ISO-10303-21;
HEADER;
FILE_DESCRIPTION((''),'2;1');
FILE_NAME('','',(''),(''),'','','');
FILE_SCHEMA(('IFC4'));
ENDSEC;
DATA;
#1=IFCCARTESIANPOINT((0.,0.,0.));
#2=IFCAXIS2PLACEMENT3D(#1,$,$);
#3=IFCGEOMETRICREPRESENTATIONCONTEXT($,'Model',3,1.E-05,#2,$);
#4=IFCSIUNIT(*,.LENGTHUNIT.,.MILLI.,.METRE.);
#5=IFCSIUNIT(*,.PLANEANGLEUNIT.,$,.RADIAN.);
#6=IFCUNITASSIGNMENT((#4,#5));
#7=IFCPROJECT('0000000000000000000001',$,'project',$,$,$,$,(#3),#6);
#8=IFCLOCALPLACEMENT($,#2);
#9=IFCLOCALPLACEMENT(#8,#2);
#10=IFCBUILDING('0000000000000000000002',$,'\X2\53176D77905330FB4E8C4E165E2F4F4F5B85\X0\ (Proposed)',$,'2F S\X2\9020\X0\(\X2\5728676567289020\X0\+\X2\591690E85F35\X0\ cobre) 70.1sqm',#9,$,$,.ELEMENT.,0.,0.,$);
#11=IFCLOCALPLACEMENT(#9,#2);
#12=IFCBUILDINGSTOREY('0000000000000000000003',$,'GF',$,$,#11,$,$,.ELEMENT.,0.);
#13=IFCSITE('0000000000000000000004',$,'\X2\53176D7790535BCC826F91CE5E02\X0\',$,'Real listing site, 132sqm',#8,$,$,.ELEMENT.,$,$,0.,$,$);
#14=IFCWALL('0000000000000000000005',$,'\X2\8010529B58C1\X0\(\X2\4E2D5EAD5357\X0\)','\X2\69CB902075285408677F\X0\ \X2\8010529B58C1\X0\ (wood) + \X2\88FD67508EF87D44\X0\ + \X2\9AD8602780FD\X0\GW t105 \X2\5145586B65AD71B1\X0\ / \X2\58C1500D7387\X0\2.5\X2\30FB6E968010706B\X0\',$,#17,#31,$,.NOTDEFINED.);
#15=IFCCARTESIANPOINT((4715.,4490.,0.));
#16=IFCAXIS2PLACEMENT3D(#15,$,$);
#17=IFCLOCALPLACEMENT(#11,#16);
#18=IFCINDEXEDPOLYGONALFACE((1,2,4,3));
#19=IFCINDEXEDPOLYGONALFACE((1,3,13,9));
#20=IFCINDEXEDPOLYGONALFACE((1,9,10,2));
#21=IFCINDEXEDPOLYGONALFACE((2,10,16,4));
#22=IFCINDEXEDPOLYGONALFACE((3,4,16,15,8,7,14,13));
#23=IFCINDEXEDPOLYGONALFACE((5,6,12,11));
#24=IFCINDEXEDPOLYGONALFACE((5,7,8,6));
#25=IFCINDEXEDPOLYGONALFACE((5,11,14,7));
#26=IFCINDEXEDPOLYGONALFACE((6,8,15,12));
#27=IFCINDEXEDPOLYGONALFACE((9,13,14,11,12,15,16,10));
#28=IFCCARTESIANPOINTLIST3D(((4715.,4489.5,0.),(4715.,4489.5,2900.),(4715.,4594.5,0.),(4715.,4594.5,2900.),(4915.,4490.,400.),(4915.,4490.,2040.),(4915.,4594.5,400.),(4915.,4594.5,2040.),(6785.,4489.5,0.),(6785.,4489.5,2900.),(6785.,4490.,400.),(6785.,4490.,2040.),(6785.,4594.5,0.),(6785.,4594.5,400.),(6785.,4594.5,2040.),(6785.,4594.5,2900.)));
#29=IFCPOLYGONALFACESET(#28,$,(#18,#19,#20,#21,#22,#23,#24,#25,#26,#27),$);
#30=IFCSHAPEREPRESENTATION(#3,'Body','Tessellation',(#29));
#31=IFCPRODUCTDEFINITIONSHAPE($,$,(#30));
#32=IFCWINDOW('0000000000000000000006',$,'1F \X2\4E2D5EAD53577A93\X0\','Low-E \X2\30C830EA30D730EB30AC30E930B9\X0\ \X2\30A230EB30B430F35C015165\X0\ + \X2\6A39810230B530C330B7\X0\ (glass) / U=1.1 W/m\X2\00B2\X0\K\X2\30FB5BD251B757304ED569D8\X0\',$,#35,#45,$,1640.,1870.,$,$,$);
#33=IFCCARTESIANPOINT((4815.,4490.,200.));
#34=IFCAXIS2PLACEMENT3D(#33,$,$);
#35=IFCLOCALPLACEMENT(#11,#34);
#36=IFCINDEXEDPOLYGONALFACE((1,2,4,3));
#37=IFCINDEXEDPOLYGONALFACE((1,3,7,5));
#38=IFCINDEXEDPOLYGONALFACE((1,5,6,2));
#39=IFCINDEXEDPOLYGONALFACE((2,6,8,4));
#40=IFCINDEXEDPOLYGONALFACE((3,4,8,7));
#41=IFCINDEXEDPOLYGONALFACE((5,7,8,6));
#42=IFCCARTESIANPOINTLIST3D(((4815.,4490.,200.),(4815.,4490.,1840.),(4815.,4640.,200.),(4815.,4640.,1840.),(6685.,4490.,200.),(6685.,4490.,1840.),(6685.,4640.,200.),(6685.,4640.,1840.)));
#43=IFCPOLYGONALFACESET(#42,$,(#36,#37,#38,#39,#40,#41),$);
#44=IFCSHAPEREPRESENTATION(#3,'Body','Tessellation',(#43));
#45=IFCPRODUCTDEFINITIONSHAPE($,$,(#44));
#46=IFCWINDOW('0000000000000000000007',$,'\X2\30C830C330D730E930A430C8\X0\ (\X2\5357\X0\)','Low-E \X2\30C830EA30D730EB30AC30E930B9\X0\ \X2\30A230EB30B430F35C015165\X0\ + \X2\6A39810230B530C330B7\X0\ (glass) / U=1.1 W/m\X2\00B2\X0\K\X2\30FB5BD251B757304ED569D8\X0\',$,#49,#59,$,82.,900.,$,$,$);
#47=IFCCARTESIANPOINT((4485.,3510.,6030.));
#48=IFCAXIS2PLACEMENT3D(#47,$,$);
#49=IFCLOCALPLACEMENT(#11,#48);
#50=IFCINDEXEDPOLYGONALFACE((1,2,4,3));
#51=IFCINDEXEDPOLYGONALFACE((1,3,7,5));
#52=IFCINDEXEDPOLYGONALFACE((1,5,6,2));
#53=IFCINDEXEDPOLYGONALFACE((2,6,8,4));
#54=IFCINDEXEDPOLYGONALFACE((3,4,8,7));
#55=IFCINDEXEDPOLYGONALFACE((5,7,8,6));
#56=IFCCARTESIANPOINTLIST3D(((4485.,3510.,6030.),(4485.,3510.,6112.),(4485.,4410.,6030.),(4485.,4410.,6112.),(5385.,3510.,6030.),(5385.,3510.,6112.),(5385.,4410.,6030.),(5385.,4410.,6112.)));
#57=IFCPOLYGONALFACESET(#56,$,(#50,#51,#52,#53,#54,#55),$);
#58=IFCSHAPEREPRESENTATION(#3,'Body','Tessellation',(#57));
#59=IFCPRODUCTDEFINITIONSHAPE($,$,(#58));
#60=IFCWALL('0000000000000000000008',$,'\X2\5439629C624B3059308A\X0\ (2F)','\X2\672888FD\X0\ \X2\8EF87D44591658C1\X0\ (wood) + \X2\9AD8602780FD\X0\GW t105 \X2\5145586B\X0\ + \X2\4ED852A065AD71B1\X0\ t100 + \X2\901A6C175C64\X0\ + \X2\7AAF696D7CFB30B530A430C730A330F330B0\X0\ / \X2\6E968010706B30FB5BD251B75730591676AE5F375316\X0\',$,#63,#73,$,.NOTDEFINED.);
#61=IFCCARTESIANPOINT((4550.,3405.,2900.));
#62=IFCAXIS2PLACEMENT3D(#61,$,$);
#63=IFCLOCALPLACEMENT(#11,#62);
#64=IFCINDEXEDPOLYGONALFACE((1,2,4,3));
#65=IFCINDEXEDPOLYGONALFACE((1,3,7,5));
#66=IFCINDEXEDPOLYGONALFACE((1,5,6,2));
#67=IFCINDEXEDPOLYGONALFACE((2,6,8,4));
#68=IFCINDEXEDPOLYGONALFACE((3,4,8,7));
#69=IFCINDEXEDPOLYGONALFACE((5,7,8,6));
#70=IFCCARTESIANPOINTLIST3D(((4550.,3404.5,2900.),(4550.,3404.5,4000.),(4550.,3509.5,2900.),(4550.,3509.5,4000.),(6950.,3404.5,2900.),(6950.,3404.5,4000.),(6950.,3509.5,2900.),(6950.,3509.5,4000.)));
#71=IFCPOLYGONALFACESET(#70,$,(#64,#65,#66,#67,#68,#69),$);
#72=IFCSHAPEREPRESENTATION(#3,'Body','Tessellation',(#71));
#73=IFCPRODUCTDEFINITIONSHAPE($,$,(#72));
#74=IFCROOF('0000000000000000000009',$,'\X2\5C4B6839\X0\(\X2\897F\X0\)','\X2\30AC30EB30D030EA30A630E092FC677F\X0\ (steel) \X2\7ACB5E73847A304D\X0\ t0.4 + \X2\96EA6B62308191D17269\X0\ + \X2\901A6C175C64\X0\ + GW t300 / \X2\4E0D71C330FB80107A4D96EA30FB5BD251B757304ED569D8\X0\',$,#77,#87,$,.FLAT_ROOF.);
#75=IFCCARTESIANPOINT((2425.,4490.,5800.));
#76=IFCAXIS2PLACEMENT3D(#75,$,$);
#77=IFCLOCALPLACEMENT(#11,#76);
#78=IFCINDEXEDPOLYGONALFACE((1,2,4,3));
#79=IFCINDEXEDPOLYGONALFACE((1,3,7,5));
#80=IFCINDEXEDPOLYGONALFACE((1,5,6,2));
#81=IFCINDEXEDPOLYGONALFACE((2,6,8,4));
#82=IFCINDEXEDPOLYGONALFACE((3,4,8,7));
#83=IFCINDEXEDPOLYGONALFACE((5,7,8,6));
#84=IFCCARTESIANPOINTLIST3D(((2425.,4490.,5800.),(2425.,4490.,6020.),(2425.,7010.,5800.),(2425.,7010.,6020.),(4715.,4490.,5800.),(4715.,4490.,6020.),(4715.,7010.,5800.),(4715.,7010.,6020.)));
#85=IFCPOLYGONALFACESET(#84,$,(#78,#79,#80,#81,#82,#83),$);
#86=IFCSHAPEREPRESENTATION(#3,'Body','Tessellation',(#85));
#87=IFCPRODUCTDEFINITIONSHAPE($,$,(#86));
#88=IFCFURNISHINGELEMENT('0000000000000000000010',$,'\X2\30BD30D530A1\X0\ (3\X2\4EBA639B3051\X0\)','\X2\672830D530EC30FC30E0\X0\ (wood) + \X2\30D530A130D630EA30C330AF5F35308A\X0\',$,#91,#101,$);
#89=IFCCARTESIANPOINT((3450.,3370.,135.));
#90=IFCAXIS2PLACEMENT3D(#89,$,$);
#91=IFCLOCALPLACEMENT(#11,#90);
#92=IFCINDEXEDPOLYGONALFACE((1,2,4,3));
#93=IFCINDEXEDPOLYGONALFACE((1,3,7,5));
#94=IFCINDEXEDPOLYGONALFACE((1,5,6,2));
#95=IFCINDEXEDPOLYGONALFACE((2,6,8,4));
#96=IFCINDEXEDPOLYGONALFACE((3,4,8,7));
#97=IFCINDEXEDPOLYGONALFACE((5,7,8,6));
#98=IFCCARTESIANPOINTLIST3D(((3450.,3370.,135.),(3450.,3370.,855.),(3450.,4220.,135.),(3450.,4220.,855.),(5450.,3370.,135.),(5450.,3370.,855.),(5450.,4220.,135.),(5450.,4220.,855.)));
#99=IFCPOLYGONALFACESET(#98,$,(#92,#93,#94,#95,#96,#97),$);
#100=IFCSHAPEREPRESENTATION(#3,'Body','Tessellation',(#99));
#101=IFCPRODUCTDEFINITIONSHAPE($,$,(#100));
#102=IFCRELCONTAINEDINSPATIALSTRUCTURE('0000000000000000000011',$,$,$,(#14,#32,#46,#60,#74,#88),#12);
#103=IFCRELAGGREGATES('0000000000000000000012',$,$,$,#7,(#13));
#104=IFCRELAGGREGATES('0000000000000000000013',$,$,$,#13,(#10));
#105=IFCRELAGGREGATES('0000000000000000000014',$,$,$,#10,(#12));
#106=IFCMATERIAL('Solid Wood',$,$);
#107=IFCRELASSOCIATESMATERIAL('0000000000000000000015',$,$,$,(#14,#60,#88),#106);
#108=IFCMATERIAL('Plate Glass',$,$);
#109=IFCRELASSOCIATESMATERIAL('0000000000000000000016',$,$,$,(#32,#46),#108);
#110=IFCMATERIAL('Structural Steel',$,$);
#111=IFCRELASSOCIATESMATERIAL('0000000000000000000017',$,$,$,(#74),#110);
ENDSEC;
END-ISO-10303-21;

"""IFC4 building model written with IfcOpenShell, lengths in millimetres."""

from ifc_helpers import new_model, si_unit, frame, frame_2d, origin, place, context, project, spatial, rectangle, extrude, material, element, fill, save


model = new_model("IFC4")

# Units and contexts
model_context = context("Model", 3, precision=1e-05, world=origin())
ifc_project = project(units=[si_unit("LENGTHUNIT", "METRE", prefix="MILLI"), si_unit("PLANEANGLEUNIT", "RADIAN")], contexts=[model_context])

# Site, building, storey
site_placement = place(None, origin())
site = spatial("IfcSite", under=ifc_project, at=site_placement, Name="北海道富良野市", ObjectType="Real listing site, 132sqm", CompositionType="ELEMENT", RefElevation=0.0)
building_placement = place(site_placement, origin())
building = spatial("IfcBuilding", under=site, at=building_placement, Name="北海道・二世帯住宅 (Proposed)", ObjectType="2F S造(在来木造+外部張 cobre) 70.1sqm", CompositionType="ELEMENT", ElevationOfRefHeight=0.0, ElevationOfTerrain=0.0)
storey_placement = place(building_placement, origin())
storey = spatial("IfcBuildingStorey", under=building, at=storey_placement, Name="GF", CompositionType="ELEMENT", Elevation=0.0)

# Shared definitions
ifc_material_1 = material(Name="Solid Wood")

# Wall, opening, window
wall_1_placement = place(storey_placement, frame((4715.0, 4490.0, 0.0)))
wall_1 = element("IfcWall", 1, at=wall_1_placement, inside=storey, material=ifc_material_1, Name="耐力壁(中庭南)", Description="構造用合板 耐力壁 (wood) + 製材軸組 + 高性能GW t105 充填断熱 / 壁倍率2.5・準耐火", PredefinedType="NOTDEFINED", context=model_context, shape_type="SweptSolid", body=[
    extrude(rectangle(XDim=2070.0, YDim=105.0, at=frame_2d((1035.0, 52.0))), frame((4715.0, 4490.0, 0.0)), (0.0, 0.0, 1.0), 2900.0),
])
opening_placement = place(storey_placement, frame((4815.0, 4490.0, 200.0)))
opening = element("IfcOpeningElement", 2, at=opening_placement, cuts=wall_1, PredefinedType="NOTDEFINED", context=model_context, shape_type="SweptSolid", body=[
    extrude(rectangle(XDim=1870.0, YDim=150.0, at=frame_2d((935.0, 75.0))), frame((4815.0, 4490.0, 200.0)), (0.0, 0.0, 1.0), 1640.0),
])
ifc_material_2 = material(Name="Plate Glass")
window_1_placement = place(storey_placement, frame((4815.0, 4490.0, 200.0)))
window_1 = element("IfcWindow", 3, at=window_1_placement, inside=storey, material=ifc_material_2, Name="1F 中庭南窓", Description="Low-E トリプルガラス アルゴン封入 + 樹脂サッシ (glass) / U=1.1 W/m²K・寒冷地仕様", OverallHeight=1640.0, OverallWidth=1870.0, context=model_context, shape_type="SweptSolid", body=[
    extrude(rectangle(XDim=1870.0, YDim=150.0, at=frame_2d((935.0, 75.0))), frame((4815.0, 4490.0, 200.0)), (0.0, 0.0, 1.0), 1640.0),
])
fill(opening, window_1)

# Window
window_2_placement = place(storey_placement, frame((4485.0, 3510.0, 6030.0)))
element("IfcWindow", 4, at=window_2_placement, inside=storey, material=ifc_material_2, Name="トップライト (南)", Description="Low-E トリプルガラス アルゴン封入 + 樹脂サッシ (glass) / U=1.1 W/m²K・寒冷地仕様", OverallHeight=82.0, OverallWidth=900.0, context=model_context, shape_type="SweptSolid", body=[
    extrude(rectangle(XDim=900.0, YDim=900.0, at=frame_2d((450.0, 450.0))), frame((4485.0, 3510.0, 6030.0)), (0.0, 0.0, 1.0), 82.0),
])

# Wall
wall_2_placement = place(storey_placement, frame((4550.0, 3405.0, 2900.0)))
element("IfcWall", 5, at=wall_2_placement, inside=storey, material=ifc_material_1, Name="吹抜手すり (2F)", Description="木製 軸組外壁 (wood) + 高性能GW t105 充填 + 付加断熱 t100 + 通気層 + 窯業系サイディング / 準耐火・寒冷地外皮強化", PredefinedType="NOTDEFINED", context=model_context, shape_type="SweptSolid", body=[
    extrude(rectangle(XDim=2400.0, YDim=105.0, at=frame_2d((1200.0, 52.0))), frame((4550.0, 3405.0, 2900.0)), (0.0, 0.0, 1.0), 1100.0),
])

# Roof
ifc_material_3 = material(Name="Structural Steel")
for number, where, name in (
    (6, (2425.0, 4490.0, 5800.0), "屋根(西)"),
):
    element("IfcRoof", number, at=place(storey_placement, frame(where)), inside=storey, material=ifc_material_3, Name=name, Description="ガルバリウム鋼板 (steel) 立平葺き t0.4 + 雪止め金物 + 通気層 + GW t300 / 不燃・耐積雪・寒冷地仕様", PredefinedType="FLAT_ROOF", context=model_context, shape_type="SweptSolid", body=[
        extrude(rectangle(XDim=2290.0, YDim=2520.0, at=frame_2d((1145.0, 1260.0))), frame((2425.0, 4490.0, 5800.0)), (0.0, 0.0, 1.0), 220.0),
    ])

# Furnishing element
furnishing_placement = place(storey_placement, frame((3450.0, 3370.0, 135.0)))
element("IfcFurnishingElement", 7, at=furnishing_placement, inside=storey, material=ifc_material_1, Name="ソファ (3人掛け)", Description="木フレーム (wood) + ファブリック張り", context=model_context, shape_type="SweptSolid", body=[
    extrude(rectangle(XDim=2000.0, YDim=850.0, at=frame_2d((1000.0, 425.0))), frame((3450.0, 3370.0, 135.0)), (0.0, 0.0, 1.0), 720.0),
])

save(model, "model.ifc")
